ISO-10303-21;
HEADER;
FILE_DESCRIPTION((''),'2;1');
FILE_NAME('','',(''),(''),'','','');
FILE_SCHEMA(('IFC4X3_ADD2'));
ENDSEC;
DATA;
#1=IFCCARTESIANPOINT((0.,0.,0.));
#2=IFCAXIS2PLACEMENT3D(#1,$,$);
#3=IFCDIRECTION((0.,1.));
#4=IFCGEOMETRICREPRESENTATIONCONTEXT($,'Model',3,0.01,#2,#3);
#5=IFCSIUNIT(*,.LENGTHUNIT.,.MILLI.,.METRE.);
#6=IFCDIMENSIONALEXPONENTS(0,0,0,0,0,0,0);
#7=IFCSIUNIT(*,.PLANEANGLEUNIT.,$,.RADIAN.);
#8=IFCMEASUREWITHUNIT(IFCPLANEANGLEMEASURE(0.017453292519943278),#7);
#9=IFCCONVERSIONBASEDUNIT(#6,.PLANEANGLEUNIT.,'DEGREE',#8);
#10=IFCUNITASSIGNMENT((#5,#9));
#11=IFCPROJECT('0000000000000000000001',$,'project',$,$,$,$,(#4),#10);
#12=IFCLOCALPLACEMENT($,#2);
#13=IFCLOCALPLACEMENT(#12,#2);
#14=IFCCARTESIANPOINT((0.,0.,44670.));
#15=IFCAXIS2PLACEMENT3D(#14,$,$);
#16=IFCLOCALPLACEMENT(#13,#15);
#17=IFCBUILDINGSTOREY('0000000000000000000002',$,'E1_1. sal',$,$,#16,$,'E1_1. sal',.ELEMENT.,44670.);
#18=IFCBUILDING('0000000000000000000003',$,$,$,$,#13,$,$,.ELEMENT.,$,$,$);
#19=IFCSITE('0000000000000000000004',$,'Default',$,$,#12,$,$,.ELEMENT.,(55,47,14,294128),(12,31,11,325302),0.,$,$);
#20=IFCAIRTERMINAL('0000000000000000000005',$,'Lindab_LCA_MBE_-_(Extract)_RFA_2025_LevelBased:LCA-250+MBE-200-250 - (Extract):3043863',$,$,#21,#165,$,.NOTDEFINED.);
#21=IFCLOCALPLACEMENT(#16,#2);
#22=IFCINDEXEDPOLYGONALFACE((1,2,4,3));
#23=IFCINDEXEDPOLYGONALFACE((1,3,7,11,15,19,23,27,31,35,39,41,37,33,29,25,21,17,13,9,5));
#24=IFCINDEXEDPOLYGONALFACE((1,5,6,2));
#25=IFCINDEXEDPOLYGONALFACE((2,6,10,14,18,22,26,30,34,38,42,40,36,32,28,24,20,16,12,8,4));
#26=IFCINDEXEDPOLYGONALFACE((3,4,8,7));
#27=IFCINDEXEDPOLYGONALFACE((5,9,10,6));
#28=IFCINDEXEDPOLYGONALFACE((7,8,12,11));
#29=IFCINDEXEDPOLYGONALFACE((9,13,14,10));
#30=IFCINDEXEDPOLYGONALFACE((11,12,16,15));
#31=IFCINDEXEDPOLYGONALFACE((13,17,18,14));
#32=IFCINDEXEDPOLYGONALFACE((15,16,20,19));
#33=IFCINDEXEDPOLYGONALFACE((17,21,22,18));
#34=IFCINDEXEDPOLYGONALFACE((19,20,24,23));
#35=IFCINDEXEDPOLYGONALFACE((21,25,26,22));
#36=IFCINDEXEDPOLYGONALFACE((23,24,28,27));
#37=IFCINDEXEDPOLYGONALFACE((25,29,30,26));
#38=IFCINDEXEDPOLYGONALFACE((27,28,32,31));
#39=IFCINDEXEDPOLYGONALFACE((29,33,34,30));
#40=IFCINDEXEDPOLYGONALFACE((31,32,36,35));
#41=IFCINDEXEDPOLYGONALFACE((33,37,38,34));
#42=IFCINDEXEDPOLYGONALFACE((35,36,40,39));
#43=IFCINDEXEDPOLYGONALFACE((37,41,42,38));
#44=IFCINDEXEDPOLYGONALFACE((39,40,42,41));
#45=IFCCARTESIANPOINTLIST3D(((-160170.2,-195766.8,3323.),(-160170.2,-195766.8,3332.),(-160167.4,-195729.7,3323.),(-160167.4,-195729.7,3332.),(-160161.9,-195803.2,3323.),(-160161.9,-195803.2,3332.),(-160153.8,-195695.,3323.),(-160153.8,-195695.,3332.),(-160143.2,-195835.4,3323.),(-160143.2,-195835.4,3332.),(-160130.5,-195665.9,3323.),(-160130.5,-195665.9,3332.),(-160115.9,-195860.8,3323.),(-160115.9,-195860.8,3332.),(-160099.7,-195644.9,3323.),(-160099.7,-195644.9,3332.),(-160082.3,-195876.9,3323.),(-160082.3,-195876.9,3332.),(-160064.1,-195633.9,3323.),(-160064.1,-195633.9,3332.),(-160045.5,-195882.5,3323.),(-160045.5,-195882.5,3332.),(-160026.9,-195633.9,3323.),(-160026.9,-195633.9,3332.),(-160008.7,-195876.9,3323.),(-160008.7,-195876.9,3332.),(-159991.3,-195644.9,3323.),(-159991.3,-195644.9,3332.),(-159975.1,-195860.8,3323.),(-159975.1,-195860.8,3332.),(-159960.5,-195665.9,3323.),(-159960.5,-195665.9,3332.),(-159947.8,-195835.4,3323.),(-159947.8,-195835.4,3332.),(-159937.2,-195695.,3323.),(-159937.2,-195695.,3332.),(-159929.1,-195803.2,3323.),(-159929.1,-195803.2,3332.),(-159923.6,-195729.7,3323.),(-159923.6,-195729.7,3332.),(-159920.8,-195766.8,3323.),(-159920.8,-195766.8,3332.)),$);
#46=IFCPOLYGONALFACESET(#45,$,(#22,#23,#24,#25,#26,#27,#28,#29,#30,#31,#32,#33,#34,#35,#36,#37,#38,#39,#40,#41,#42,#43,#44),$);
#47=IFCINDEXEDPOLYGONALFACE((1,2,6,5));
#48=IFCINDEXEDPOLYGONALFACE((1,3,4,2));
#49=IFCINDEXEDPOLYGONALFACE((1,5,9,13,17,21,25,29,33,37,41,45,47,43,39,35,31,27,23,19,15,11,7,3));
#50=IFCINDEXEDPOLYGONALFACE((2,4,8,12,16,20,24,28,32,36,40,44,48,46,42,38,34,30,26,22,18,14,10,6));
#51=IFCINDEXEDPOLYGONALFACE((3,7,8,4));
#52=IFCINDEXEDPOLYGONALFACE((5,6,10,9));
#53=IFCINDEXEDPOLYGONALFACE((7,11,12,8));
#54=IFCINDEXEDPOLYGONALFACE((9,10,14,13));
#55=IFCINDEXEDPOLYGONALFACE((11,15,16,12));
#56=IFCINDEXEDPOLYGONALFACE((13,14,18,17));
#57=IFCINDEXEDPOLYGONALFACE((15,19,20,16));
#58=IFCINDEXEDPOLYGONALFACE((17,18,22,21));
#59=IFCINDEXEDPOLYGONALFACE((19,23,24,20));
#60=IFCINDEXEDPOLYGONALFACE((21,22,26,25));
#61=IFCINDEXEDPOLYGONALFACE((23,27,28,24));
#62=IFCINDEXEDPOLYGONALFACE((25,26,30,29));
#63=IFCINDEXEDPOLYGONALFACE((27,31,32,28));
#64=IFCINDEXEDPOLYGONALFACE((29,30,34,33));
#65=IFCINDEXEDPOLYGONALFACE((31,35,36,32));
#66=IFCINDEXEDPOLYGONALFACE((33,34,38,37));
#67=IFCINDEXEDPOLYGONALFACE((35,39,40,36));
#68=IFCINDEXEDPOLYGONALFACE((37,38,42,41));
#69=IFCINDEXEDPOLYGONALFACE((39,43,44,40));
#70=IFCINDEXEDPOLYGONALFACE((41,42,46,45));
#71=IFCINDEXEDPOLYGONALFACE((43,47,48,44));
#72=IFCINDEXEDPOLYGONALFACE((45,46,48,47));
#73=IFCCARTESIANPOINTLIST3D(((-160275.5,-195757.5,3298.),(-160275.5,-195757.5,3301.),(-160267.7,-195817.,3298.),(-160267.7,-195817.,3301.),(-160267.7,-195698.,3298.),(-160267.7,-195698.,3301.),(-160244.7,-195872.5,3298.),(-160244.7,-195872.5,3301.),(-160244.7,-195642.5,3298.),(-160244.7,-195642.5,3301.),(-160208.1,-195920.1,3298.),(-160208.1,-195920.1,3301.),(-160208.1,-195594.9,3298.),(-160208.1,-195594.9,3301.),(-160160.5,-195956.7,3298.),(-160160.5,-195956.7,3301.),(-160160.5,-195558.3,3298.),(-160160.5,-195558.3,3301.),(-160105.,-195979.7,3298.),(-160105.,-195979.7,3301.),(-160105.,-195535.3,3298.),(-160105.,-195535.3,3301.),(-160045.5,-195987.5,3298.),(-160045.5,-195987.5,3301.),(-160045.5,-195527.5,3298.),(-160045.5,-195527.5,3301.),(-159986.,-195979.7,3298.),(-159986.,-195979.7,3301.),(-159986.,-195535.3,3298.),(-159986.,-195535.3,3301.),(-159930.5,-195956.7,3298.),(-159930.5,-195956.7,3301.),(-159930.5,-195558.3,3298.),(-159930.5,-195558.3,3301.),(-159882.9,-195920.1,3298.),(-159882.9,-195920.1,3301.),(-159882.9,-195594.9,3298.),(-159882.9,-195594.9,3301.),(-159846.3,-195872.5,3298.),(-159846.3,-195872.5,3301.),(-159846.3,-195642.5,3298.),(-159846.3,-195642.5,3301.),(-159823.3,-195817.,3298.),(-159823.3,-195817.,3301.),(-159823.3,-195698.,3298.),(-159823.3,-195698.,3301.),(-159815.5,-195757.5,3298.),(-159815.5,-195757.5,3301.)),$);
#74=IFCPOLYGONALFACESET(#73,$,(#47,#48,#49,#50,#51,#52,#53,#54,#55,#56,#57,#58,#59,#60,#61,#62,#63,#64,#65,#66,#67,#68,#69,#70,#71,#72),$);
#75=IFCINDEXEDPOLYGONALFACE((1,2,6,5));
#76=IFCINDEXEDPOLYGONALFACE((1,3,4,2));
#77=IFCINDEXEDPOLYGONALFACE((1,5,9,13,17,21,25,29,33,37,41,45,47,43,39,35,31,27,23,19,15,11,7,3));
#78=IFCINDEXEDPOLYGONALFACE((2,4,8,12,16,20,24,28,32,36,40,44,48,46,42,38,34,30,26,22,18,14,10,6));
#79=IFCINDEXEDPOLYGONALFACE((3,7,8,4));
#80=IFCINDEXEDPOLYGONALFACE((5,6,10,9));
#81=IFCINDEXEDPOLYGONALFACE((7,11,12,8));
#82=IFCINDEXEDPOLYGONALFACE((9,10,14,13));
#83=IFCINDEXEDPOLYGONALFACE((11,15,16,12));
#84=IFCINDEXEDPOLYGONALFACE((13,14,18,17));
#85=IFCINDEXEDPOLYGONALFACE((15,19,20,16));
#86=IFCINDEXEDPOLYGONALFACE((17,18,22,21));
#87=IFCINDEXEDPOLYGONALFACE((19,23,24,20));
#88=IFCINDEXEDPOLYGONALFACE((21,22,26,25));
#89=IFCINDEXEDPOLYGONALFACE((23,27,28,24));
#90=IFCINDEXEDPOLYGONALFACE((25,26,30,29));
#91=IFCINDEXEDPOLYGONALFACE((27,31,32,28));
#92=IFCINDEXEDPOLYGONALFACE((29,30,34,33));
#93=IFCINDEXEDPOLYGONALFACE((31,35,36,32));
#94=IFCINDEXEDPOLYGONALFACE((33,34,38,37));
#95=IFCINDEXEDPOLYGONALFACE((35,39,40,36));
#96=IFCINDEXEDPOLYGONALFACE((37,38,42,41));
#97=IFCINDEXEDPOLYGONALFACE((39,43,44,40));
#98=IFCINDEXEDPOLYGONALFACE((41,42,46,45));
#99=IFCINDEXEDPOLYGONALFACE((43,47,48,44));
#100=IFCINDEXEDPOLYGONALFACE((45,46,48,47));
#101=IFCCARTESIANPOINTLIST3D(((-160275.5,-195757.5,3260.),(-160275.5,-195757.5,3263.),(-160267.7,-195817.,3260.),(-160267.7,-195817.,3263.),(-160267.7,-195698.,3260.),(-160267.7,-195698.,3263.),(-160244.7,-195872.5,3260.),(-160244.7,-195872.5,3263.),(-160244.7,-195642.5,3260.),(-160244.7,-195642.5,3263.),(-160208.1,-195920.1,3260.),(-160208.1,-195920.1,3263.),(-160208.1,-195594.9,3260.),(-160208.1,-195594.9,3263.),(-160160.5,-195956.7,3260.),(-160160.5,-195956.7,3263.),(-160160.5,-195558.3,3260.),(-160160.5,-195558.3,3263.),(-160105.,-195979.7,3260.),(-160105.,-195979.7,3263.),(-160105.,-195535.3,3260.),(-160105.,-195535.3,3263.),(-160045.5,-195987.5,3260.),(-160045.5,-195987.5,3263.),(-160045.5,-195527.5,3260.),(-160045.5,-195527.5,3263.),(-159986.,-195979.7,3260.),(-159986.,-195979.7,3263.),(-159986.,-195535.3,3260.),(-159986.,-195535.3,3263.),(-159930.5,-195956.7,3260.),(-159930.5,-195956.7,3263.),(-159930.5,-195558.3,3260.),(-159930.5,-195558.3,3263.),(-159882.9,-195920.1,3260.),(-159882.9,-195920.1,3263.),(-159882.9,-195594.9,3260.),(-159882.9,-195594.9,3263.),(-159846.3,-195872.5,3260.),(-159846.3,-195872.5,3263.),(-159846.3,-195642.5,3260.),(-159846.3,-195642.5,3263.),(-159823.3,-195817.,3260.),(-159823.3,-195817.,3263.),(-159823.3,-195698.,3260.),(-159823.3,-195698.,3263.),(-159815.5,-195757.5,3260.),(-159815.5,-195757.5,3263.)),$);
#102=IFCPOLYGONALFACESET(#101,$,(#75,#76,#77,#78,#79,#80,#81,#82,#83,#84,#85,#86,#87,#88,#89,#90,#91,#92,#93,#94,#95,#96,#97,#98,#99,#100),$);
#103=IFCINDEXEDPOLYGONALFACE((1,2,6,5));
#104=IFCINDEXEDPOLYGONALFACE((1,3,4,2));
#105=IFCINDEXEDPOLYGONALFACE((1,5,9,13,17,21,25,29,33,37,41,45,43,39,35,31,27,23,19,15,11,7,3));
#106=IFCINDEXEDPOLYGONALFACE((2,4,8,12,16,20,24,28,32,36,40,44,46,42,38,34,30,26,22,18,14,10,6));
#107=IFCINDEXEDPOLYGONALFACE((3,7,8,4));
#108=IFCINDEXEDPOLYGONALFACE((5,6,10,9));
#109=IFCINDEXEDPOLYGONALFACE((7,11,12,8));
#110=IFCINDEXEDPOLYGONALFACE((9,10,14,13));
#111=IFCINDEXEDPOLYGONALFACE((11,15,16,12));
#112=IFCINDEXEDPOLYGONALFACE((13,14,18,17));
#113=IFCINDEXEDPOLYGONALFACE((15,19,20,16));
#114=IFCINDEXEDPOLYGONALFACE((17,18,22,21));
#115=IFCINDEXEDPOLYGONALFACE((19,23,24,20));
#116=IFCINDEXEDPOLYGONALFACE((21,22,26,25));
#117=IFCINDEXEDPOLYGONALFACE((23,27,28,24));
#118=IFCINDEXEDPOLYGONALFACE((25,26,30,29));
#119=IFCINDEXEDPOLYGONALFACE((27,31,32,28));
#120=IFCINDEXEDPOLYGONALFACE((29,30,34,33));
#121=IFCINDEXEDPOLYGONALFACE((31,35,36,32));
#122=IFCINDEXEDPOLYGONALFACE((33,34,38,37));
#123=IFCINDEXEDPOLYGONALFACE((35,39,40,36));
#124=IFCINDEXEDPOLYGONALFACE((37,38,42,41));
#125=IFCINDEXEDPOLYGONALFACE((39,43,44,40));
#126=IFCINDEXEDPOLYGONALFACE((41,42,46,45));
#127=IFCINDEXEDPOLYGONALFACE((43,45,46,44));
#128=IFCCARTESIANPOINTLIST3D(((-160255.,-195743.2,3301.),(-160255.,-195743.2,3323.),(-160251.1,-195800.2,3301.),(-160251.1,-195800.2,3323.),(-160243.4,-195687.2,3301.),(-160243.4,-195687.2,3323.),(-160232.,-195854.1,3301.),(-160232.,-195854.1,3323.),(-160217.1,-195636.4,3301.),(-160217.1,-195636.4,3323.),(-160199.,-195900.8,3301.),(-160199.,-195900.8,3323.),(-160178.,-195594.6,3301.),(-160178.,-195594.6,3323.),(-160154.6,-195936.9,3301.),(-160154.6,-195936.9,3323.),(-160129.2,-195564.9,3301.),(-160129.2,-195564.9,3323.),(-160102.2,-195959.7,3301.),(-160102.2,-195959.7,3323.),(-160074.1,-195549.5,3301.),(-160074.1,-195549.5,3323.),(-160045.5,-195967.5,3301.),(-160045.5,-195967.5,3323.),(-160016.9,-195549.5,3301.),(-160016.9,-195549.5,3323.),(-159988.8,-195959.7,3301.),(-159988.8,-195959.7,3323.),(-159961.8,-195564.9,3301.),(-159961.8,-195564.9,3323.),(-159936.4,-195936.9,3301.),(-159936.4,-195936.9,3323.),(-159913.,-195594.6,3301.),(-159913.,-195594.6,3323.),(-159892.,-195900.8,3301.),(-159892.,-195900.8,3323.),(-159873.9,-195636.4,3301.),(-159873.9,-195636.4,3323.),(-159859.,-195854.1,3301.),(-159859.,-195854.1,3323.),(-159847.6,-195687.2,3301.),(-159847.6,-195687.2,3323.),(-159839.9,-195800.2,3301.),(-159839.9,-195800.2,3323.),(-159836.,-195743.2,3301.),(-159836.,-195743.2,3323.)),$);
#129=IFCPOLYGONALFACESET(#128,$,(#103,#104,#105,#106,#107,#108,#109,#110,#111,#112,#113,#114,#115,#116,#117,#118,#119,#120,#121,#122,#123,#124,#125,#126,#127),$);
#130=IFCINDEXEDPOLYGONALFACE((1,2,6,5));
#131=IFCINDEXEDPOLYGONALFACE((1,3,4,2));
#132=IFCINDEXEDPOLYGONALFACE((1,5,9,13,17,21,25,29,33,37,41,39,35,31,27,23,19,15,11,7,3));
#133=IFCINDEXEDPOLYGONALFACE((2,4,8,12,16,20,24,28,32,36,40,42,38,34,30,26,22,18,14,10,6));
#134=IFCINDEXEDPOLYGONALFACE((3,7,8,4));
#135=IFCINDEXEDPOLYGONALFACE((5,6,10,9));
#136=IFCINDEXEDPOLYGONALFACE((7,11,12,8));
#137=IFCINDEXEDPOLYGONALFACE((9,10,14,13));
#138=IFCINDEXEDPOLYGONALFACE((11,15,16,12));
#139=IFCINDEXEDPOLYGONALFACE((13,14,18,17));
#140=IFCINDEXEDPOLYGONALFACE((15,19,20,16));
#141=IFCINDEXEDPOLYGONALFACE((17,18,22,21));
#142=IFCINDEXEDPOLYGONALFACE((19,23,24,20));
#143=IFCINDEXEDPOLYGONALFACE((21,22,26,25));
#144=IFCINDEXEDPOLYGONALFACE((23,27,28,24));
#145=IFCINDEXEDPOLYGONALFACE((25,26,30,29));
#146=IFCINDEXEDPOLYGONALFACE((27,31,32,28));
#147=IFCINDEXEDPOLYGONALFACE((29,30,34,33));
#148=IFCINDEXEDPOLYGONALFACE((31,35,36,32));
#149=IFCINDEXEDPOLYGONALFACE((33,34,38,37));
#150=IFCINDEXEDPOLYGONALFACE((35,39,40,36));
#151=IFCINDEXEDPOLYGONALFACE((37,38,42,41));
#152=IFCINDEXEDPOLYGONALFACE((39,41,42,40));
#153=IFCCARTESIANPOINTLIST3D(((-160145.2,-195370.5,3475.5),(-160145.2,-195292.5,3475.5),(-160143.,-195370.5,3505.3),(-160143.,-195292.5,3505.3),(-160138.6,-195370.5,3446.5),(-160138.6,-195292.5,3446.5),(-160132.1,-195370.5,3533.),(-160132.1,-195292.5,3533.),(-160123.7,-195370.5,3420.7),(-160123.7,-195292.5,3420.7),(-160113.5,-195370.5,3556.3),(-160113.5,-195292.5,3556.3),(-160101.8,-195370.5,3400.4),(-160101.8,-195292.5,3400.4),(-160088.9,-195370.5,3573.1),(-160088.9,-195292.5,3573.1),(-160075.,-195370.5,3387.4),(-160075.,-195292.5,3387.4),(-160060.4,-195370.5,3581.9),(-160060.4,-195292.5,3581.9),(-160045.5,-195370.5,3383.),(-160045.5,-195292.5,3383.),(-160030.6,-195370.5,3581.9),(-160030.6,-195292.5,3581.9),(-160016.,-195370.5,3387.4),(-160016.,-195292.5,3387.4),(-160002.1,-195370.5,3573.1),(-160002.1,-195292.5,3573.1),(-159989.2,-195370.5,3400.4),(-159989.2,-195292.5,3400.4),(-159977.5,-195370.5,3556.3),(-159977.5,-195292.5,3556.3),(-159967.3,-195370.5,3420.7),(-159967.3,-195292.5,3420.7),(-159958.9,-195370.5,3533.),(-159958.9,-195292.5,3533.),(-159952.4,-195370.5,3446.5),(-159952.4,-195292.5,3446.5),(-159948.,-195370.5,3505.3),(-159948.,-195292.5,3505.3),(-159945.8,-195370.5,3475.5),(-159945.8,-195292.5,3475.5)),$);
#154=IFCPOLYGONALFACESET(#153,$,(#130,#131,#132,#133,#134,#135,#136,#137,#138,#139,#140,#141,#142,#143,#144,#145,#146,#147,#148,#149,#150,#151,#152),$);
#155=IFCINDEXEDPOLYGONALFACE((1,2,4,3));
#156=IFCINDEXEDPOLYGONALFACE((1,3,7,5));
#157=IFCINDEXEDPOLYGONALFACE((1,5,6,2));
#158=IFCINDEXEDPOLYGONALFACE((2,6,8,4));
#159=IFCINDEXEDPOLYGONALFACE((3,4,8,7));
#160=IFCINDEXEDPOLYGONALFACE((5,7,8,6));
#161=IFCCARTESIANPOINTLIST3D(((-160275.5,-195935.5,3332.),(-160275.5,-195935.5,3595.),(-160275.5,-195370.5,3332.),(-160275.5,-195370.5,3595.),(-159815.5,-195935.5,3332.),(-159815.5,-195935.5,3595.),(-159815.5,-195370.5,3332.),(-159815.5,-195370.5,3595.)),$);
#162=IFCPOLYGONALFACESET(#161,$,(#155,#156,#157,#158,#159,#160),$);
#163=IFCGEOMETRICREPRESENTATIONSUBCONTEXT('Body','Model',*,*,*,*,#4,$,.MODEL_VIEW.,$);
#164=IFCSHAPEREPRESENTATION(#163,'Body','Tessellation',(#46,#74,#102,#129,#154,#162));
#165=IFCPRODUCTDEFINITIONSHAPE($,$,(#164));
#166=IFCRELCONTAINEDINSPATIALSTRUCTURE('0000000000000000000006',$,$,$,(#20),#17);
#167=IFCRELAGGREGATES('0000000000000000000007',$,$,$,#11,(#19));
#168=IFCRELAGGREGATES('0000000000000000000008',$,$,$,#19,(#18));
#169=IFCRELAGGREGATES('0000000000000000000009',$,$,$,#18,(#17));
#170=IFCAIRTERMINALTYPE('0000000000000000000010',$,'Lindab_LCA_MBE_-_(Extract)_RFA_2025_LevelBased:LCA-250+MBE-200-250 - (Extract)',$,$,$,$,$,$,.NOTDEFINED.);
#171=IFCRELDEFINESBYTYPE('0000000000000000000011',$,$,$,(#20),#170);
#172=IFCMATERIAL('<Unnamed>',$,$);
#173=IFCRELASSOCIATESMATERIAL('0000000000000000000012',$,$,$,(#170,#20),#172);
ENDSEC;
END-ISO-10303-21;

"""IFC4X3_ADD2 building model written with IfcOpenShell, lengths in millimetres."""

from ifc_helpers import new_model, entity, si_unit, converted_unit, direction, frame, frame_2d, origin, origin_2d_with_axis, place, context, subcontext, project, spatial, rectangle, circle, extrude, source, transform, mapped, material, type_object, type_shapes, element, save


model = new_model("IFC4X3_ADD2")

# Units and contexts
model_context = context("Model", 3, precision=0.01, world=origin(), true_north=direction((0.0, 1.0)))
body_context = subcontext(model_context, "Body", "Model", "MODEL_VIEW")
ifc_project = project(units=[si_unit("LENGTHUNIT", "METRE", prefix="MILLI"), converted_unit("PLANEANGLEUNIT", "DEGREE", entity("IfcPlaneAngleMeasure", 0.017453292519943278), si_unit("PLANEANGLEUNIT", "RADIAN"), dimensions=[0, 0, 0, 0, 0, 0, 0])], contexts=[model_context])

# Site, building, storey
site_placement = place(None, origin())
site = spatial("IfcSite", under=ifc_project, at=site_placement, Name="Default", CompositionType="ELEMENT", RefLatitude=(55, 47, 14, 294128), RefLongitude=(12, 31, 11, 325302), RefElevation=0.0)
building_placement = place(site_placement, origin())
building = spatial("IfcBuilding", under=site, at=building_placement, CompositionType="ELEMENT")
storey_placement = place(building_placement, frame((0.0, 0.0, 44670.0)))
storey = spatial("IfcBuildingStorey", under=building, at=storey_placement, Name="E1_1. sal", LongName="E1_1. sal", CompositionType="ELEMENT", Elevation=44670.0)

# Air terminal
ifc_material_1 = material(Name="<Unnamed>")
air_terminal_type_1 = type_object("IfcAirTerminalType", Name="Lindab_LCA_MBE_-_(Extract)_RFA_2025_LevelBased:LCA-250+MBE-200-250 - (Extract)", PredefinedType="NOTDEFINED", material=ifc_material_1)
shared_shape_1 = source(origin(), body_context, "Body", "SweptSolid", [
    extrude(circle(Radius=125.0, at=frame_2d((0.0, 0.0), x_axis=(1.0, 0.0))), frame((0.0, 0.0, 22.0)), (0.0, 0.0, 1.0), 9.0),
    extrude(circle(Radius=230.0, at=frame_2d((0.0, 0.0), x_axis=(1.0, 0.0))), frame((0.0, 0.0, -3.0)), (0.0, 0.0, 1.0), 3.0),
    extrude(circle(Radius=230.0, at=frame_2d((0.0, 0.0), x_axis=(1.0, 0.0))), frame((0.0, 0.0, -41.0)), (0.0, 0.0, 1.0), 3.0),
    extrude(circle(Radius=210.0, at=frame_2d((0.0, 0.0), x_axis=(1.0, 0.0))), origin(), (0.0, 0.0, 1.0), 22.0),
    extrude(circle(Radius=100.0, at=frame_2d((0.0, 0.0), x_axis=(1.0, 0.0))), frame((-465.0, 0.0, 182.0), z_axis=(1.0, 0.0, 0.0), x_axis=(0.0, 0.0, -1.0)), (0.0, 0.0, 1.0), 78.0),
    extrude(rectangle(XDim=460.0, YDim=565.0, at=origin_2d_with_axis()), frame((-104.5, 0.0, 31.0), z_axis=(0.0, 0.0, 1.0), x_axis=(0.0, -1.0, 0.0)), (0.0, 0.0, 1.0), 263.0),
])
type_shapes(air_terminal_type_1, [shared_shape_1])
for number, where, z_axis, x_axis, name in (
    (1, (-160045.5, -195757.5, 3301.0), (0.0, 0.0, 1.0), (0.0, -1.0, 0.0), "Lindab_LCA_MBE_-_(Extract)_RFA_2025_LevelBased:LCA-250+MBE-200-250 - (Extract):3043863"),
):
    element("IfcAirTerminal", number, at=place(storey_placement, frame(where, z_axis=z_axis, x_axis=x_axis)), inside=storey, type_object=air_terminal_type_1, material=ifc_material_1, Name=name, PredefinedType="NOTDEFINED", context=body_context, shape_type="MappedRepresentation", body=[
        mapped(shared_shape_1, transform((0.0, 0.0, 0.0), scale=1.0)),
    ])

save(model, "model.ifc")
